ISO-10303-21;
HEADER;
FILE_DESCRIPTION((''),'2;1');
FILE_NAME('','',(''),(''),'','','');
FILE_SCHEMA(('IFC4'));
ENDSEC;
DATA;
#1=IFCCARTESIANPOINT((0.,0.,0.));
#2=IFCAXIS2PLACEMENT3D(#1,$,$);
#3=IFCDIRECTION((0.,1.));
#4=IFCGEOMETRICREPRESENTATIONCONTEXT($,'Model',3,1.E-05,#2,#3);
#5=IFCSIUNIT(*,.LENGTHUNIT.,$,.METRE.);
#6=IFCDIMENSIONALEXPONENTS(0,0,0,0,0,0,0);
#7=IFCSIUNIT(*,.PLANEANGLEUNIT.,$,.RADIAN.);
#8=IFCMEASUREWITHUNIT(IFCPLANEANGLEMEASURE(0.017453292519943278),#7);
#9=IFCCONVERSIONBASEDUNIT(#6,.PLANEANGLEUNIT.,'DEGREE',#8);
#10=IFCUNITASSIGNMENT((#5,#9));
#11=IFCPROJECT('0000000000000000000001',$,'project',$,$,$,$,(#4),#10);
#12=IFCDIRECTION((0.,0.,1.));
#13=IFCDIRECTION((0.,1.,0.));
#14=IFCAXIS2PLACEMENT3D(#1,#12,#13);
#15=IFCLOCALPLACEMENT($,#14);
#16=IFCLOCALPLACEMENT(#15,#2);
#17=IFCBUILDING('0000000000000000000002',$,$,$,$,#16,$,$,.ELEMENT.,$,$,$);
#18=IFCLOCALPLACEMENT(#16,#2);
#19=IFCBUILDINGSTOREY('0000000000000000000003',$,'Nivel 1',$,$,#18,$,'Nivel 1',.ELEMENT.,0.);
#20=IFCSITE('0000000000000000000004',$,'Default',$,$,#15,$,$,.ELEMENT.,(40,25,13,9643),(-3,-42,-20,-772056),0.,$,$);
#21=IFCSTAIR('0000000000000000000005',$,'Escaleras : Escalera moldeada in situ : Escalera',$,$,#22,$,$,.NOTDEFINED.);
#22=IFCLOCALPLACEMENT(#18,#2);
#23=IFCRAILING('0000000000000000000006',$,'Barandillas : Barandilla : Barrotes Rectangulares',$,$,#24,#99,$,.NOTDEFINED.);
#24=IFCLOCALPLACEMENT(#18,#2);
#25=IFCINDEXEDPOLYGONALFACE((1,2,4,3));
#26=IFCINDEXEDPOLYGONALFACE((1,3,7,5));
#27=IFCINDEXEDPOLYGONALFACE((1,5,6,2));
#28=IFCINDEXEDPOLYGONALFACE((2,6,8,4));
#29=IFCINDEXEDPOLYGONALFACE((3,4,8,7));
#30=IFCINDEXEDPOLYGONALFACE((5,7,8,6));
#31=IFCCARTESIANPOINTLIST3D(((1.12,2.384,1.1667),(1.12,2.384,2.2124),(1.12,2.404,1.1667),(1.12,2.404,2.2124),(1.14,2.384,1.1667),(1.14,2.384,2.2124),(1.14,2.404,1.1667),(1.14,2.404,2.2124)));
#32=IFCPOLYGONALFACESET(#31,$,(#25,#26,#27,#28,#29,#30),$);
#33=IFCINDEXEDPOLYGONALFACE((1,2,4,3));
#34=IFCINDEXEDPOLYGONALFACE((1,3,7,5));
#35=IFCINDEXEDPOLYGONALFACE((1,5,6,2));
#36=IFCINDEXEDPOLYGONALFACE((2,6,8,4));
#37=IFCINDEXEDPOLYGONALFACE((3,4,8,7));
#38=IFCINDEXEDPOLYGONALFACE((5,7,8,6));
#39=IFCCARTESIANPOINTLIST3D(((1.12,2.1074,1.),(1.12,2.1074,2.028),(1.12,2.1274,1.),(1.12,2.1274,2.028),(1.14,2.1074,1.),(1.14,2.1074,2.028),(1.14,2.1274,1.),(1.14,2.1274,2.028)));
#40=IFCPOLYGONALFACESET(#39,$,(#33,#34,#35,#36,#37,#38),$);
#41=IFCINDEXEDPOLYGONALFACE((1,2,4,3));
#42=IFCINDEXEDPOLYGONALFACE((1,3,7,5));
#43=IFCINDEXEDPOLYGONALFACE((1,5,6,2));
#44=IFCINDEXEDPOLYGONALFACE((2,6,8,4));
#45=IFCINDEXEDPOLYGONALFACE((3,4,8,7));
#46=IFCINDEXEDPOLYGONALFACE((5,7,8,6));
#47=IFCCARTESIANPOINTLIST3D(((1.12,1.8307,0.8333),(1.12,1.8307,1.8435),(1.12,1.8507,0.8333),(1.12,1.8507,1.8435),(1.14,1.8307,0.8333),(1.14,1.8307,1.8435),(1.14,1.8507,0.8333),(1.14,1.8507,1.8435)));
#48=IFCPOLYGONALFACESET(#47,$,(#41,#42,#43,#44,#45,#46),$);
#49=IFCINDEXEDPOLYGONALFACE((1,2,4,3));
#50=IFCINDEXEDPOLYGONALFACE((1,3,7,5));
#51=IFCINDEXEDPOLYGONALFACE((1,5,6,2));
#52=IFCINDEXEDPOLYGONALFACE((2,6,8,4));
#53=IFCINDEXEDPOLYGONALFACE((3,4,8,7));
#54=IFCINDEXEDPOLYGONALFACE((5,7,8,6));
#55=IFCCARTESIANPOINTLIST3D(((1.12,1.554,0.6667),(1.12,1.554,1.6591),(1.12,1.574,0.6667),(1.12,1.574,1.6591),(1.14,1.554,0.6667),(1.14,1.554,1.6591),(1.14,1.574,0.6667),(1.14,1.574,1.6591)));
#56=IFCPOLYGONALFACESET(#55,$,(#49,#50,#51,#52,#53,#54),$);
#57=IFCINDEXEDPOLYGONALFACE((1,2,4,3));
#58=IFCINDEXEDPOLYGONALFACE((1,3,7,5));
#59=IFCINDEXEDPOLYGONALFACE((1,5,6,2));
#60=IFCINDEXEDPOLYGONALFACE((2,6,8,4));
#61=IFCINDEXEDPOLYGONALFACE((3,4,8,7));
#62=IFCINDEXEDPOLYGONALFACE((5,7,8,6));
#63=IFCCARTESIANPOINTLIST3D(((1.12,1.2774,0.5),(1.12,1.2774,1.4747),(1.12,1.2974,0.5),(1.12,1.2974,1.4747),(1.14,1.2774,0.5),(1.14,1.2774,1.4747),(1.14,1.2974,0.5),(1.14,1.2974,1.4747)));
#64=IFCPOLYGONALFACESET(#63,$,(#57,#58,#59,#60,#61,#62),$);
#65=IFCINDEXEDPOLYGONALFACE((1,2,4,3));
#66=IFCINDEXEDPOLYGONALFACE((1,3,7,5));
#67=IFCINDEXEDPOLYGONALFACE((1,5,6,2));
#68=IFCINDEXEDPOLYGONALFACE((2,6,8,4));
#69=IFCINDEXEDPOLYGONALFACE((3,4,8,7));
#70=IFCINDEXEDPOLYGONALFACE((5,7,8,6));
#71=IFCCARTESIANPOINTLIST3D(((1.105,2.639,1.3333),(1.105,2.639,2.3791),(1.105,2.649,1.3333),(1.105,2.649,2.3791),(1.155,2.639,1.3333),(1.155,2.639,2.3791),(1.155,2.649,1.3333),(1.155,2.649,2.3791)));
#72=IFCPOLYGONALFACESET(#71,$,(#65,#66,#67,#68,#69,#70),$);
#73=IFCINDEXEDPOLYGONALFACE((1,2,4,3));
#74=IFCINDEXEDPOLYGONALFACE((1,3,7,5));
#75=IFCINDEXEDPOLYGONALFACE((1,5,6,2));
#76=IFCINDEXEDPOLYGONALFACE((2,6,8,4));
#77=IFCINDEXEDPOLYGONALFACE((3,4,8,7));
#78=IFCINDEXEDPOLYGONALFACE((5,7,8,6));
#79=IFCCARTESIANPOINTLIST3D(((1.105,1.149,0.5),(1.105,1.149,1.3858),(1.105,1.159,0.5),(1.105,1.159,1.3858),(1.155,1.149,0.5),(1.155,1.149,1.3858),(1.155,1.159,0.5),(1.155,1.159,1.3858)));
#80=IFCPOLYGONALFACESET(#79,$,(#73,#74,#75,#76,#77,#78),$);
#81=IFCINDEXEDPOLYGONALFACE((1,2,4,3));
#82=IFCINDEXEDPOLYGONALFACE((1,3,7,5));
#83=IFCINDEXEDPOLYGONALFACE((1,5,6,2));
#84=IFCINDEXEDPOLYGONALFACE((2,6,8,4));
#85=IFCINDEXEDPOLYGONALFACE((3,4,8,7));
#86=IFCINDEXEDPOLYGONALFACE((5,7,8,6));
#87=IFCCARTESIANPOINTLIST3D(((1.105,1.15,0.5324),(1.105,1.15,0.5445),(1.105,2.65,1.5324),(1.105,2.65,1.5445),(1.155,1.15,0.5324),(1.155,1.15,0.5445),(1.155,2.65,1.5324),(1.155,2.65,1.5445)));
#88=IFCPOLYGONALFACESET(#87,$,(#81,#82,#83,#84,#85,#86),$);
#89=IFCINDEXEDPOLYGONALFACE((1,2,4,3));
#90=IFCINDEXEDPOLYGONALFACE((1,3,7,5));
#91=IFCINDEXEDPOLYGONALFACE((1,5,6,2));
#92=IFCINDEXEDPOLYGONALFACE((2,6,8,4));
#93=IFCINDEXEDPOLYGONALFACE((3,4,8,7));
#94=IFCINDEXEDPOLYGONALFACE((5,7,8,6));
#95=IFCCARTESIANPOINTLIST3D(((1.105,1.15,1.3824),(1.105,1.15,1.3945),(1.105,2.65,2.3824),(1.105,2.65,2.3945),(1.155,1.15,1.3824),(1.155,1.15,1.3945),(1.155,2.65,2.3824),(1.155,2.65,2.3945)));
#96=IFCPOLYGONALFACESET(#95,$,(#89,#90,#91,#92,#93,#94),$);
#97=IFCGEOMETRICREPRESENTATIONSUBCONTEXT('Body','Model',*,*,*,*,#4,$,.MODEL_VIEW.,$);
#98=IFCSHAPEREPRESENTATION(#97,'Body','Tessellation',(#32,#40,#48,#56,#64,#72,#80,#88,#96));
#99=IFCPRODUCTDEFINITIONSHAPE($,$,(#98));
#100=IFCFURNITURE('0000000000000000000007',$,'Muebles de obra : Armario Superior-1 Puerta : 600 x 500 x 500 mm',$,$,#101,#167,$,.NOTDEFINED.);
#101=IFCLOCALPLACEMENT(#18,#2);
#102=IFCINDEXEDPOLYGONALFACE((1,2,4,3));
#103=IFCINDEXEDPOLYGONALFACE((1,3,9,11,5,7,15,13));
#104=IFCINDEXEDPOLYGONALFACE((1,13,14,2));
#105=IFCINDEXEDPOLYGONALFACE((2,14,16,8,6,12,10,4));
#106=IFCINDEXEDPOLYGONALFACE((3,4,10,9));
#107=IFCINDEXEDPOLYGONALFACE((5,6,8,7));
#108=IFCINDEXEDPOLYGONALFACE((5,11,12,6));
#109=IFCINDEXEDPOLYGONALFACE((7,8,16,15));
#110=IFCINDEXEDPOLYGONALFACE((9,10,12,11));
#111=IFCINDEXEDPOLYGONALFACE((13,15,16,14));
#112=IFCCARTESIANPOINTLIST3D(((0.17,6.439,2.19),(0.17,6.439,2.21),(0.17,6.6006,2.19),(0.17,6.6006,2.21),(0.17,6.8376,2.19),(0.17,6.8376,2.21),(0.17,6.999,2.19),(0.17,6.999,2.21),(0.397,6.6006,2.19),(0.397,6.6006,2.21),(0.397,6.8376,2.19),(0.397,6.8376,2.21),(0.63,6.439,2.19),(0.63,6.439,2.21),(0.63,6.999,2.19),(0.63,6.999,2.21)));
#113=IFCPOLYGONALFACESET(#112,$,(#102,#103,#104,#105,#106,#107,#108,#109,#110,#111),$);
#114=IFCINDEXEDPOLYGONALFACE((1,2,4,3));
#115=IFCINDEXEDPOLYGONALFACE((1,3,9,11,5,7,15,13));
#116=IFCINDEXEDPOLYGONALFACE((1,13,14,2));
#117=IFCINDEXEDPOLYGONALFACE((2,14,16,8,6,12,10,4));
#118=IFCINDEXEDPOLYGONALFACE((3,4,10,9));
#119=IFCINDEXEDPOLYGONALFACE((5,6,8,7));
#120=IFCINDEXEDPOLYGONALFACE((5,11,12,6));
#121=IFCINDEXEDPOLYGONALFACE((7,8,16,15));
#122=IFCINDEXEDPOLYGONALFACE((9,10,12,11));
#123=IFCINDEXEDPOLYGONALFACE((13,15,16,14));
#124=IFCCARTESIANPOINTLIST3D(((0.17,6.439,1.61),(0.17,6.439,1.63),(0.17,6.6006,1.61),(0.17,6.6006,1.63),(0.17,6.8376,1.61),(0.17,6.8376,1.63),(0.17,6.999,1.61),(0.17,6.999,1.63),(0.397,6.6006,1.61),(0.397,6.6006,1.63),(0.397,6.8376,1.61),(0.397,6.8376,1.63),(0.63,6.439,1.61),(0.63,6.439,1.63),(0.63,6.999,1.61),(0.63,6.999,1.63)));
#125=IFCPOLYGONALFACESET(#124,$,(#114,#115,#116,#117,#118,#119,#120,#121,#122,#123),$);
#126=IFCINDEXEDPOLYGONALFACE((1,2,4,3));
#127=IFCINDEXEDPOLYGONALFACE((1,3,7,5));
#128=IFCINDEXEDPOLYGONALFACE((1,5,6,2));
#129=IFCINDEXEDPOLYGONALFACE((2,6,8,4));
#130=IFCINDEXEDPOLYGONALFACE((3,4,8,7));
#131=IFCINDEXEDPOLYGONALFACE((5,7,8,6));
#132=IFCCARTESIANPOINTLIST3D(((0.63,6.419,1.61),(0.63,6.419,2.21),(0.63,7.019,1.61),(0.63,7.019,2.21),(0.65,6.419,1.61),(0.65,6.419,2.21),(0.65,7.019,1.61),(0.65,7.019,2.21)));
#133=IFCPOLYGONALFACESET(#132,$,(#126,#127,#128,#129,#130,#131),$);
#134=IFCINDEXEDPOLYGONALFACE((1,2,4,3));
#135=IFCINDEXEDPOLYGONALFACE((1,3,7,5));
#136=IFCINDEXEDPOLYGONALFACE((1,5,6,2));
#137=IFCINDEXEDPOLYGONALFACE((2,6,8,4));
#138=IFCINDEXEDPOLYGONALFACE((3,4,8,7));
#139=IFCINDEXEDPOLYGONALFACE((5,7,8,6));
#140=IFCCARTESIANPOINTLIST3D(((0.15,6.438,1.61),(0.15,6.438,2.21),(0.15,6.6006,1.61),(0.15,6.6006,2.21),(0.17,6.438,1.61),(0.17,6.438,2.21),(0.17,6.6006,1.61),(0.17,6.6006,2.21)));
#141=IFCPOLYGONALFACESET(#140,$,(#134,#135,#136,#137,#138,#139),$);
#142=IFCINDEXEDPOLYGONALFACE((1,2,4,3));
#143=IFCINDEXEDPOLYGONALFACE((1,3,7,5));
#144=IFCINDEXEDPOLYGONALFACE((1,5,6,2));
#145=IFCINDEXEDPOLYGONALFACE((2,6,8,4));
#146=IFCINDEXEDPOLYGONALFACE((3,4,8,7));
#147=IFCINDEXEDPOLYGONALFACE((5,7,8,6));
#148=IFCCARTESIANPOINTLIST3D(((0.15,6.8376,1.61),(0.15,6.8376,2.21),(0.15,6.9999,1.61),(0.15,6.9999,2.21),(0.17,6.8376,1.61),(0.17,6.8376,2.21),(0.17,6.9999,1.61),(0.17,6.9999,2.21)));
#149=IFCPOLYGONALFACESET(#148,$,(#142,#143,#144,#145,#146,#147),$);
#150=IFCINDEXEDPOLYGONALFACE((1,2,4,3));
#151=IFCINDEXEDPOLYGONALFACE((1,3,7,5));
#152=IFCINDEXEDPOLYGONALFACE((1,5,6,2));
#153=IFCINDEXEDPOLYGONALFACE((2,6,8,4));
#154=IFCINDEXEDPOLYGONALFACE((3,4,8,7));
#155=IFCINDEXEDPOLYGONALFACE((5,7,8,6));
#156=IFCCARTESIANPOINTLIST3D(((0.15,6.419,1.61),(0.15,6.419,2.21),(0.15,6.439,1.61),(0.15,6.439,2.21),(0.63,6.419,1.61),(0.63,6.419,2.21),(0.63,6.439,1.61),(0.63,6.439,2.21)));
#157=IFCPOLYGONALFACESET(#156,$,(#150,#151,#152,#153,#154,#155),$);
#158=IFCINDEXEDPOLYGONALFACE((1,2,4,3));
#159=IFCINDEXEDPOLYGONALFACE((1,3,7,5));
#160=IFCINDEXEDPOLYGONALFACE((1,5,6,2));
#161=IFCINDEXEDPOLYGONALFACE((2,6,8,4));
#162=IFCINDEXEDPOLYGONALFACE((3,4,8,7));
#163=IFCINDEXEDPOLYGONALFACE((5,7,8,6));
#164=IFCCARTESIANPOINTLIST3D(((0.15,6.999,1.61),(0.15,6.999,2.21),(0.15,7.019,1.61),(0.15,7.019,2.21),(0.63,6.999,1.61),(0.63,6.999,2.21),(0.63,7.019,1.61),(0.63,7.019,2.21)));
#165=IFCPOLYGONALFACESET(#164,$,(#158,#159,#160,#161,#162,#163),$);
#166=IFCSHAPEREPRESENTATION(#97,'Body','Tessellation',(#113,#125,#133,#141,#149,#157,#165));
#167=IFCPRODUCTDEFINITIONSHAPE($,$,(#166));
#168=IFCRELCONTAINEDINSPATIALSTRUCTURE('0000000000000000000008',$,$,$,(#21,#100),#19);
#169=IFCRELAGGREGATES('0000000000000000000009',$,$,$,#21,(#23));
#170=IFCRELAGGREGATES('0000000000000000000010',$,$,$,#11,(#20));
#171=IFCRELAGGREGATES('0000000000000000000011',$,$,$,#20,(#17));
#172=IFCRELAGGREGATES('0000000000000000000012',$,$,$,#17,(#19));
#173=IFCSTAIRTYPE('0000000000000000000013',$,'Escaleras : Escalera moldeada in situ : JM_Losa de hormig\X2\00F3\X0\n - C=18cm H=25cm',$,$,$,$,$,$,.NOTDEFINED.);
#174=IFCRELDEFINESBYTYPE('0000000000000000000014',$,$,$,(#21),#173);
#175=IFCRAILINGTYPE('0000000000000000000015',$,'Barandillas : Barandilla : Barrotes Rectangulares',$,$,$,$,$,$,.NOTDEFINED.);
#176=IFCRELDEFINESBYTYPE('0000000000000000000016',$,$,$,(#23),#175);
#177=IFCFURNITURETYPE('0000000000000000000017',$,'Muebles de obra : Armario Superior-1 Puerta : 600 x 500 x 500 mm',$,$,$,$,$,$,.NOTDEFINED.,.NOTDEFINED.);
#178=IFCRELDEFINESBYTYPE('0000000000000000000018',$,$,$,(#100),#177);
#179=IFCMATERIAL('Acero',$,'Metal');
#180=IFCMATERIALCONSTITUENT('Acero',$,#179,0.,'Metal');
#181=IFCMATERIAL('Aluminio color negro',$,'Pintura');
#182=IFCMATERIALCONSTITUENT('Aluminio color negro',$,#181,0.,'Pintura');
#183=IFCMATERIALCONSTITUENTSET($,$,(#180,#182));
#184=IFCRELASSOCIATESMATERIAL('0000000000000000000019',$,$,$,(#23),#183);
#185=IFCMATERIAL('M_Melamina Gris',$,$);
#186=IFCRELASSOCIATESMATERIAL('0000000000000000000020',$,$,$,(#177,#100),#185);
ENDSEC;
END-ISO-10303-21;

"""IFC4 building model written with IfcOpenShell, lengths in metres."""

from ifc_helpers import new_model, entity, si_unit, converted_unit, direction, frame, origin, place, context, subcontext, project, spatial, indexed_curve, outline, extrude, source, transform, mapped, material, constituent, constituent_set, type_object, type_shapes, element, aggregate, save


model = new_model("IFC4")

# Units and contexts
model_context = context("Model", 3, precision=1e-05, world=origin(), true_north=direction((0.0, 1.0)))
body_context = subcontext(model_context, "Body", "Model", "MODEL_VIEW")
ifc_project = project(units=[si_unit("LENGTHUNIT", "METRE"), converted_unit("PLANEANGLEUNIT", "DEGREE", entity("IfcPlaneAngleMeasure", 0.017453292519943278), si_unit("PLANEANGLEUNIT", "RADIAN"), dimensions=[0, 0, 0, 0, 0, 0, 0])], contexts=[model_context])

# Site, building, storey
site_placement = place(None, frame((0.0, 0.0, 0.0), z_axis=(0.0, 0.0, 1.0), x_axis=(0.0, 1.0, 0.0)))
site = spatial("IfcSite", under=ifc_project, at=site_placement, Name="Default", CompositionType="ELEMENT", RefLatitude=(40, 25, 13, 9643), RefLongitude=(-3, -42, -20, -772056), RefElevation=0.0)
building_placement = place(site_placement, origin())
building = spatial("IfcBuilding", under=site, at=building_placement, CompositionType="ELEMENT")
storey_placement = place(building_placement, origin())
storey = spatial("IfcBuildingStorey", under=building, at=storey_placement, Name="Nivel 1", LongName="Nivel 1", CompositionType="ELEMENT", Elevation=0.0)

# Stair, railing
stair_type = type_object("IfcStairType", Name="Escaleras : Escalera moldeada in situ : JM_Losa de hormigón - C=18cm H=25cm", PredefinedType="NOTDEFINED")
stair_placement = place(storey_placement, origin())
stair = element("IfcStair", 1, at=stair_placement, inside=storey, type_object=stair_type, Name="Escaleras : Escalera moldeada in situ : Escalera", PredefinedType="NOTDEFINED")
ifc_material_1 = material(Name="Acero", Category="Metal")
ifc_constituent_1 = constituent(ifc_material_1, Name="Acero", Category="Metal", fraction=0.0)
ifc_material_2 = material(Name="Aluminio color negro", Category="Pintura")
ifc_constituent_2 = constituent(ifc_material_2, Name="Aluminio color negro", Category="Pintura", fraction=0.0)
ifc_constituent_set = constituent_set(constituents=[ifc_constituent_1, ifc_constituent_2])
railing_type = type_object("IfcRailingType", Name="Barandillas : Barandilla : Barrotes Rectangulares", PredefinedType="NOTDEFINED")
railing_placement = place(stair_placement, origin())
railing = element("IfcRailing", 2, at=railing_placement, type_object=railing_type, material=ifc_constituent_set, Name="Barandillas : Barandilla : Barrotes Rectangulares", PredefinedType="NOTDEFINED", context=body_context, shape_type="SweptSolid", body=[
    extrude(outline(indexed_curve([(-0.01, -0.01), (0.01, -0.01), (0.01, 0.01), (-0.01, 0.01), (-0.01, -0.01)], self_intersect=False)), frame((1.13, 2.394, 1.1667)), (0.0, 0.0, 1.0), 1.0458),
    extrude(outline(indexed_curve([(-0.01, -0.01), (0.01, -0.01), (0.01, 0.01), (-0.01, 0.01), (-0.01, -0.01)], self_intersect=False)), frame((1.13, 2.1174, 1.0)), (0.0, 0.0, 1.0), 1.028),
    extrude(outline(indexed_curve([(-0.01, -0.01), (0.01, -0.01), (0.01, 0.01), (-0.01, 0.01), (-0.01, -0.01)], self_intersect=False)), frame((1.13, 1.8407, 0.8333)), (0.0, 0.0, 1.0), 1.0102),
    extrude(outline(indexed_curve([(-0.01, -0.01), (0.01, -0.01), (0.01, 0.01), (-0.01, 0.01), (-0.01, -0.01)], self_intersect=False)), frame((1.13, 1.564, 0.6667)), (0.0, 0.0, 1.0), 0.9924),
    extrude(outline(indexed_curve([(-0.01, -0.01), (0.01, -0.01), (0.01, 0.01), (-0.01, 0.01), (-0.01, -0.01)], self_intersect=False)), frame((1.13, 1.2874, 0.5)), (0.0, 0.0, 1.0), 0.9747),
    extrude(outline(indexed_curve([(-0.025, -0.005), (0.025, -0.005), (0.025, 0.005), (-0.025, 0.005), (-0.025, -0.005)], self_intersect=False)), frame((1.13, 2.644, 1.3333)), (0.0, 0.0, 1.0), 1.0458),
    extrude(outline(indexed_curve([(-0.025, -0.005), (0.025, -0.005), (0.025, 0.005), (-0.025, 0.005), (-0.025, -0.005)], self_intersect=False)), frame((1.13, 1.154, 0.5)), (0.0, 0.0, 1.0), 0.8858),
    extrude(outline(indexed_curve([(-0.9047, -0.005), (0.8981, -0.005), (0.9047, 0.005), (-0.8981, 0.005), (-0.9047, -0.005)], self_intersect=False)), frame((1.105, 1.9, 1.0384), z_axis=(1.0, 0.0, 0.0), x_axis=(0.0, 0.83205, 0.5547)), (0.0, 0.0, 1.0), 0.05),
    extrude(outline(indexed_curve([(-0.9047, -0.005), (0.8981, -0.005), (0.9047, 0.005), (-0.8981, 0.005), (-0.9047, -0.005)], self_intersect=False)), frame((1.105, 1.9, 1.8884), z_axis=(1.0, 0.0, 0.0), x_axis=(0.0, 0.83205, 0.5547)), (0.0, 0.0, 1.0), 0.05),
])
aggregate(stair, [railing])

# Furniture
ifc_material_3 = material(Name="M_Melamina Gris")
furniture_type_1 = type_object("IfcFurnitureType", Name="Muebles de obra : Armario Superior-1 Puerta : 600 x 500 x 500 mm", AssemblyPlace="NOTDEFINED", PredefinedType="NOTDEFINED", material=ifc_material_3)
shared_shape_1 = source(origin(), body_context, "Body", "SweptSolid", [
    extrude(outline(indexed_curve([(-0.2799, -0.1718), (-0.1186, -0.1718), (-0.1186, 0.0553), (0.1184, 0.0553), (0.1184, -0.1718), (0.2801, -0.1718), (0.2801, 0.2882), (-0.2799, 0.2882), (-0.2799, -0.1718)], self_intersect=False)), frame((0.3418, 6.7191, 2.19), z_axis=(0.0, 0.0, 1.0), x_axis=(0.0, -1.0, 0.0)), (0.0, 0.0, 1.0), 0.02),
    extrude(outline(indexed_curve([(-0.2799, -0.1718), (-0.1186, -0.1718), (-0.1186, 0.0553), (0.1184, 0.0553), (0.1184, -0.1718), (0.2801, -0.1718), (0.2801, 0.2882), (-0.2799, 0.2882), (-0.2799, -0.1718)], self_intersect=False)), frame((0.3418, 6.7191, 1.61), z_axis=(0.0, 0.0, 1.0), x_axis=(0.0, -1.0, 0.0)), (0.0, 0.0, 1.0), 0.02),
    extrude(outline(indexed_curve([(-0.3, -0.01), (0.3, -0.01), (0.3, 0.01), (-0.3, 0.01), (-0.3, -0.01)], self_intersect=False)), frame((0.64, 6.719, 1.61), z_axis=(0.0, 0.0, 1.0), x_axis=(0.0, -1.0, 0.0)), (0.0, 0.0, 1.0), 0.6),
    extrude(outline(indexed_curve([(-0.0813, -0.01), (0.0813, -0.01), (0.0813, 0.01), (-0.0813, 0.01), (-0.0813, -0.01)], self_intersect=False)), frame((0.16, 6.5193, 1.61), z_axis=(0.0, 0.0, 1.0), x_axis=(0.0, 1.0, 0.0)), (0.0, 0.0, 1.0), 0.6),
    extrude(outline(indexed_curve([(-0.0812, -0.01), (0.0812, -0.01), (0.0812, 0.01), (-0.0812, 0.01), (-0.0812, -0.01)], self_intersect=False)), frame((0.16, 6.9188, 1.61), z_axis=(0.0, 0.0, 1.0), x_axis=(0.0, -1.0, 0.0)), (0.0, 0.0, 1.0), 0.6),
    extrude(outline(indexed_curve([(-0.24, -0.01), (0.24, -0.01), (0.24, 0.01), (-0.24, 0.01), (-0.24, -0.01)], self_intersect=False)), frame((0.39, 6.429, 1.61), z_axis=(0.0, 0.0, 1.0), x_axis=(-1.0, 0.0, 0.0)), (0.0, 0.0, 1.0), 0.6),
    extrude(outline(indexed_curve([(-0.01, -0.24), (0.01, -0.24), (0.01, 0.24), (-0.01, 0.24), (-0.01, -0.24)], self_intersect=False)), frame((0.39, 7.009, 1.61), z_axis=(0.0, 0.0, 1.0), x_axis=(0.0, 1.0, 0.0)), (0.0, 0.0, 1.0), 0.6),
])
type_shapes(furniture_type_1, [shared_shape_1])
furniture_1_placement = place(storey_placement, origin())
element("IfcFurniture", 3, at=furniture_1_placement, inside=storey, type_object=furniture_type_1, material=ifc_material_3, Name="Muebles de obra : Armario Superior-1 Puerta : 600 x 500 x 500 mm", PredefinedType="NOTDEFINED", context=body_context, shape_type="MappedRepresentation", body=[
    mapped(shared_shape_1, transform((0.0, 0.0, 0.0), scale=1.0)),
])

save(model, "model.ifc")
